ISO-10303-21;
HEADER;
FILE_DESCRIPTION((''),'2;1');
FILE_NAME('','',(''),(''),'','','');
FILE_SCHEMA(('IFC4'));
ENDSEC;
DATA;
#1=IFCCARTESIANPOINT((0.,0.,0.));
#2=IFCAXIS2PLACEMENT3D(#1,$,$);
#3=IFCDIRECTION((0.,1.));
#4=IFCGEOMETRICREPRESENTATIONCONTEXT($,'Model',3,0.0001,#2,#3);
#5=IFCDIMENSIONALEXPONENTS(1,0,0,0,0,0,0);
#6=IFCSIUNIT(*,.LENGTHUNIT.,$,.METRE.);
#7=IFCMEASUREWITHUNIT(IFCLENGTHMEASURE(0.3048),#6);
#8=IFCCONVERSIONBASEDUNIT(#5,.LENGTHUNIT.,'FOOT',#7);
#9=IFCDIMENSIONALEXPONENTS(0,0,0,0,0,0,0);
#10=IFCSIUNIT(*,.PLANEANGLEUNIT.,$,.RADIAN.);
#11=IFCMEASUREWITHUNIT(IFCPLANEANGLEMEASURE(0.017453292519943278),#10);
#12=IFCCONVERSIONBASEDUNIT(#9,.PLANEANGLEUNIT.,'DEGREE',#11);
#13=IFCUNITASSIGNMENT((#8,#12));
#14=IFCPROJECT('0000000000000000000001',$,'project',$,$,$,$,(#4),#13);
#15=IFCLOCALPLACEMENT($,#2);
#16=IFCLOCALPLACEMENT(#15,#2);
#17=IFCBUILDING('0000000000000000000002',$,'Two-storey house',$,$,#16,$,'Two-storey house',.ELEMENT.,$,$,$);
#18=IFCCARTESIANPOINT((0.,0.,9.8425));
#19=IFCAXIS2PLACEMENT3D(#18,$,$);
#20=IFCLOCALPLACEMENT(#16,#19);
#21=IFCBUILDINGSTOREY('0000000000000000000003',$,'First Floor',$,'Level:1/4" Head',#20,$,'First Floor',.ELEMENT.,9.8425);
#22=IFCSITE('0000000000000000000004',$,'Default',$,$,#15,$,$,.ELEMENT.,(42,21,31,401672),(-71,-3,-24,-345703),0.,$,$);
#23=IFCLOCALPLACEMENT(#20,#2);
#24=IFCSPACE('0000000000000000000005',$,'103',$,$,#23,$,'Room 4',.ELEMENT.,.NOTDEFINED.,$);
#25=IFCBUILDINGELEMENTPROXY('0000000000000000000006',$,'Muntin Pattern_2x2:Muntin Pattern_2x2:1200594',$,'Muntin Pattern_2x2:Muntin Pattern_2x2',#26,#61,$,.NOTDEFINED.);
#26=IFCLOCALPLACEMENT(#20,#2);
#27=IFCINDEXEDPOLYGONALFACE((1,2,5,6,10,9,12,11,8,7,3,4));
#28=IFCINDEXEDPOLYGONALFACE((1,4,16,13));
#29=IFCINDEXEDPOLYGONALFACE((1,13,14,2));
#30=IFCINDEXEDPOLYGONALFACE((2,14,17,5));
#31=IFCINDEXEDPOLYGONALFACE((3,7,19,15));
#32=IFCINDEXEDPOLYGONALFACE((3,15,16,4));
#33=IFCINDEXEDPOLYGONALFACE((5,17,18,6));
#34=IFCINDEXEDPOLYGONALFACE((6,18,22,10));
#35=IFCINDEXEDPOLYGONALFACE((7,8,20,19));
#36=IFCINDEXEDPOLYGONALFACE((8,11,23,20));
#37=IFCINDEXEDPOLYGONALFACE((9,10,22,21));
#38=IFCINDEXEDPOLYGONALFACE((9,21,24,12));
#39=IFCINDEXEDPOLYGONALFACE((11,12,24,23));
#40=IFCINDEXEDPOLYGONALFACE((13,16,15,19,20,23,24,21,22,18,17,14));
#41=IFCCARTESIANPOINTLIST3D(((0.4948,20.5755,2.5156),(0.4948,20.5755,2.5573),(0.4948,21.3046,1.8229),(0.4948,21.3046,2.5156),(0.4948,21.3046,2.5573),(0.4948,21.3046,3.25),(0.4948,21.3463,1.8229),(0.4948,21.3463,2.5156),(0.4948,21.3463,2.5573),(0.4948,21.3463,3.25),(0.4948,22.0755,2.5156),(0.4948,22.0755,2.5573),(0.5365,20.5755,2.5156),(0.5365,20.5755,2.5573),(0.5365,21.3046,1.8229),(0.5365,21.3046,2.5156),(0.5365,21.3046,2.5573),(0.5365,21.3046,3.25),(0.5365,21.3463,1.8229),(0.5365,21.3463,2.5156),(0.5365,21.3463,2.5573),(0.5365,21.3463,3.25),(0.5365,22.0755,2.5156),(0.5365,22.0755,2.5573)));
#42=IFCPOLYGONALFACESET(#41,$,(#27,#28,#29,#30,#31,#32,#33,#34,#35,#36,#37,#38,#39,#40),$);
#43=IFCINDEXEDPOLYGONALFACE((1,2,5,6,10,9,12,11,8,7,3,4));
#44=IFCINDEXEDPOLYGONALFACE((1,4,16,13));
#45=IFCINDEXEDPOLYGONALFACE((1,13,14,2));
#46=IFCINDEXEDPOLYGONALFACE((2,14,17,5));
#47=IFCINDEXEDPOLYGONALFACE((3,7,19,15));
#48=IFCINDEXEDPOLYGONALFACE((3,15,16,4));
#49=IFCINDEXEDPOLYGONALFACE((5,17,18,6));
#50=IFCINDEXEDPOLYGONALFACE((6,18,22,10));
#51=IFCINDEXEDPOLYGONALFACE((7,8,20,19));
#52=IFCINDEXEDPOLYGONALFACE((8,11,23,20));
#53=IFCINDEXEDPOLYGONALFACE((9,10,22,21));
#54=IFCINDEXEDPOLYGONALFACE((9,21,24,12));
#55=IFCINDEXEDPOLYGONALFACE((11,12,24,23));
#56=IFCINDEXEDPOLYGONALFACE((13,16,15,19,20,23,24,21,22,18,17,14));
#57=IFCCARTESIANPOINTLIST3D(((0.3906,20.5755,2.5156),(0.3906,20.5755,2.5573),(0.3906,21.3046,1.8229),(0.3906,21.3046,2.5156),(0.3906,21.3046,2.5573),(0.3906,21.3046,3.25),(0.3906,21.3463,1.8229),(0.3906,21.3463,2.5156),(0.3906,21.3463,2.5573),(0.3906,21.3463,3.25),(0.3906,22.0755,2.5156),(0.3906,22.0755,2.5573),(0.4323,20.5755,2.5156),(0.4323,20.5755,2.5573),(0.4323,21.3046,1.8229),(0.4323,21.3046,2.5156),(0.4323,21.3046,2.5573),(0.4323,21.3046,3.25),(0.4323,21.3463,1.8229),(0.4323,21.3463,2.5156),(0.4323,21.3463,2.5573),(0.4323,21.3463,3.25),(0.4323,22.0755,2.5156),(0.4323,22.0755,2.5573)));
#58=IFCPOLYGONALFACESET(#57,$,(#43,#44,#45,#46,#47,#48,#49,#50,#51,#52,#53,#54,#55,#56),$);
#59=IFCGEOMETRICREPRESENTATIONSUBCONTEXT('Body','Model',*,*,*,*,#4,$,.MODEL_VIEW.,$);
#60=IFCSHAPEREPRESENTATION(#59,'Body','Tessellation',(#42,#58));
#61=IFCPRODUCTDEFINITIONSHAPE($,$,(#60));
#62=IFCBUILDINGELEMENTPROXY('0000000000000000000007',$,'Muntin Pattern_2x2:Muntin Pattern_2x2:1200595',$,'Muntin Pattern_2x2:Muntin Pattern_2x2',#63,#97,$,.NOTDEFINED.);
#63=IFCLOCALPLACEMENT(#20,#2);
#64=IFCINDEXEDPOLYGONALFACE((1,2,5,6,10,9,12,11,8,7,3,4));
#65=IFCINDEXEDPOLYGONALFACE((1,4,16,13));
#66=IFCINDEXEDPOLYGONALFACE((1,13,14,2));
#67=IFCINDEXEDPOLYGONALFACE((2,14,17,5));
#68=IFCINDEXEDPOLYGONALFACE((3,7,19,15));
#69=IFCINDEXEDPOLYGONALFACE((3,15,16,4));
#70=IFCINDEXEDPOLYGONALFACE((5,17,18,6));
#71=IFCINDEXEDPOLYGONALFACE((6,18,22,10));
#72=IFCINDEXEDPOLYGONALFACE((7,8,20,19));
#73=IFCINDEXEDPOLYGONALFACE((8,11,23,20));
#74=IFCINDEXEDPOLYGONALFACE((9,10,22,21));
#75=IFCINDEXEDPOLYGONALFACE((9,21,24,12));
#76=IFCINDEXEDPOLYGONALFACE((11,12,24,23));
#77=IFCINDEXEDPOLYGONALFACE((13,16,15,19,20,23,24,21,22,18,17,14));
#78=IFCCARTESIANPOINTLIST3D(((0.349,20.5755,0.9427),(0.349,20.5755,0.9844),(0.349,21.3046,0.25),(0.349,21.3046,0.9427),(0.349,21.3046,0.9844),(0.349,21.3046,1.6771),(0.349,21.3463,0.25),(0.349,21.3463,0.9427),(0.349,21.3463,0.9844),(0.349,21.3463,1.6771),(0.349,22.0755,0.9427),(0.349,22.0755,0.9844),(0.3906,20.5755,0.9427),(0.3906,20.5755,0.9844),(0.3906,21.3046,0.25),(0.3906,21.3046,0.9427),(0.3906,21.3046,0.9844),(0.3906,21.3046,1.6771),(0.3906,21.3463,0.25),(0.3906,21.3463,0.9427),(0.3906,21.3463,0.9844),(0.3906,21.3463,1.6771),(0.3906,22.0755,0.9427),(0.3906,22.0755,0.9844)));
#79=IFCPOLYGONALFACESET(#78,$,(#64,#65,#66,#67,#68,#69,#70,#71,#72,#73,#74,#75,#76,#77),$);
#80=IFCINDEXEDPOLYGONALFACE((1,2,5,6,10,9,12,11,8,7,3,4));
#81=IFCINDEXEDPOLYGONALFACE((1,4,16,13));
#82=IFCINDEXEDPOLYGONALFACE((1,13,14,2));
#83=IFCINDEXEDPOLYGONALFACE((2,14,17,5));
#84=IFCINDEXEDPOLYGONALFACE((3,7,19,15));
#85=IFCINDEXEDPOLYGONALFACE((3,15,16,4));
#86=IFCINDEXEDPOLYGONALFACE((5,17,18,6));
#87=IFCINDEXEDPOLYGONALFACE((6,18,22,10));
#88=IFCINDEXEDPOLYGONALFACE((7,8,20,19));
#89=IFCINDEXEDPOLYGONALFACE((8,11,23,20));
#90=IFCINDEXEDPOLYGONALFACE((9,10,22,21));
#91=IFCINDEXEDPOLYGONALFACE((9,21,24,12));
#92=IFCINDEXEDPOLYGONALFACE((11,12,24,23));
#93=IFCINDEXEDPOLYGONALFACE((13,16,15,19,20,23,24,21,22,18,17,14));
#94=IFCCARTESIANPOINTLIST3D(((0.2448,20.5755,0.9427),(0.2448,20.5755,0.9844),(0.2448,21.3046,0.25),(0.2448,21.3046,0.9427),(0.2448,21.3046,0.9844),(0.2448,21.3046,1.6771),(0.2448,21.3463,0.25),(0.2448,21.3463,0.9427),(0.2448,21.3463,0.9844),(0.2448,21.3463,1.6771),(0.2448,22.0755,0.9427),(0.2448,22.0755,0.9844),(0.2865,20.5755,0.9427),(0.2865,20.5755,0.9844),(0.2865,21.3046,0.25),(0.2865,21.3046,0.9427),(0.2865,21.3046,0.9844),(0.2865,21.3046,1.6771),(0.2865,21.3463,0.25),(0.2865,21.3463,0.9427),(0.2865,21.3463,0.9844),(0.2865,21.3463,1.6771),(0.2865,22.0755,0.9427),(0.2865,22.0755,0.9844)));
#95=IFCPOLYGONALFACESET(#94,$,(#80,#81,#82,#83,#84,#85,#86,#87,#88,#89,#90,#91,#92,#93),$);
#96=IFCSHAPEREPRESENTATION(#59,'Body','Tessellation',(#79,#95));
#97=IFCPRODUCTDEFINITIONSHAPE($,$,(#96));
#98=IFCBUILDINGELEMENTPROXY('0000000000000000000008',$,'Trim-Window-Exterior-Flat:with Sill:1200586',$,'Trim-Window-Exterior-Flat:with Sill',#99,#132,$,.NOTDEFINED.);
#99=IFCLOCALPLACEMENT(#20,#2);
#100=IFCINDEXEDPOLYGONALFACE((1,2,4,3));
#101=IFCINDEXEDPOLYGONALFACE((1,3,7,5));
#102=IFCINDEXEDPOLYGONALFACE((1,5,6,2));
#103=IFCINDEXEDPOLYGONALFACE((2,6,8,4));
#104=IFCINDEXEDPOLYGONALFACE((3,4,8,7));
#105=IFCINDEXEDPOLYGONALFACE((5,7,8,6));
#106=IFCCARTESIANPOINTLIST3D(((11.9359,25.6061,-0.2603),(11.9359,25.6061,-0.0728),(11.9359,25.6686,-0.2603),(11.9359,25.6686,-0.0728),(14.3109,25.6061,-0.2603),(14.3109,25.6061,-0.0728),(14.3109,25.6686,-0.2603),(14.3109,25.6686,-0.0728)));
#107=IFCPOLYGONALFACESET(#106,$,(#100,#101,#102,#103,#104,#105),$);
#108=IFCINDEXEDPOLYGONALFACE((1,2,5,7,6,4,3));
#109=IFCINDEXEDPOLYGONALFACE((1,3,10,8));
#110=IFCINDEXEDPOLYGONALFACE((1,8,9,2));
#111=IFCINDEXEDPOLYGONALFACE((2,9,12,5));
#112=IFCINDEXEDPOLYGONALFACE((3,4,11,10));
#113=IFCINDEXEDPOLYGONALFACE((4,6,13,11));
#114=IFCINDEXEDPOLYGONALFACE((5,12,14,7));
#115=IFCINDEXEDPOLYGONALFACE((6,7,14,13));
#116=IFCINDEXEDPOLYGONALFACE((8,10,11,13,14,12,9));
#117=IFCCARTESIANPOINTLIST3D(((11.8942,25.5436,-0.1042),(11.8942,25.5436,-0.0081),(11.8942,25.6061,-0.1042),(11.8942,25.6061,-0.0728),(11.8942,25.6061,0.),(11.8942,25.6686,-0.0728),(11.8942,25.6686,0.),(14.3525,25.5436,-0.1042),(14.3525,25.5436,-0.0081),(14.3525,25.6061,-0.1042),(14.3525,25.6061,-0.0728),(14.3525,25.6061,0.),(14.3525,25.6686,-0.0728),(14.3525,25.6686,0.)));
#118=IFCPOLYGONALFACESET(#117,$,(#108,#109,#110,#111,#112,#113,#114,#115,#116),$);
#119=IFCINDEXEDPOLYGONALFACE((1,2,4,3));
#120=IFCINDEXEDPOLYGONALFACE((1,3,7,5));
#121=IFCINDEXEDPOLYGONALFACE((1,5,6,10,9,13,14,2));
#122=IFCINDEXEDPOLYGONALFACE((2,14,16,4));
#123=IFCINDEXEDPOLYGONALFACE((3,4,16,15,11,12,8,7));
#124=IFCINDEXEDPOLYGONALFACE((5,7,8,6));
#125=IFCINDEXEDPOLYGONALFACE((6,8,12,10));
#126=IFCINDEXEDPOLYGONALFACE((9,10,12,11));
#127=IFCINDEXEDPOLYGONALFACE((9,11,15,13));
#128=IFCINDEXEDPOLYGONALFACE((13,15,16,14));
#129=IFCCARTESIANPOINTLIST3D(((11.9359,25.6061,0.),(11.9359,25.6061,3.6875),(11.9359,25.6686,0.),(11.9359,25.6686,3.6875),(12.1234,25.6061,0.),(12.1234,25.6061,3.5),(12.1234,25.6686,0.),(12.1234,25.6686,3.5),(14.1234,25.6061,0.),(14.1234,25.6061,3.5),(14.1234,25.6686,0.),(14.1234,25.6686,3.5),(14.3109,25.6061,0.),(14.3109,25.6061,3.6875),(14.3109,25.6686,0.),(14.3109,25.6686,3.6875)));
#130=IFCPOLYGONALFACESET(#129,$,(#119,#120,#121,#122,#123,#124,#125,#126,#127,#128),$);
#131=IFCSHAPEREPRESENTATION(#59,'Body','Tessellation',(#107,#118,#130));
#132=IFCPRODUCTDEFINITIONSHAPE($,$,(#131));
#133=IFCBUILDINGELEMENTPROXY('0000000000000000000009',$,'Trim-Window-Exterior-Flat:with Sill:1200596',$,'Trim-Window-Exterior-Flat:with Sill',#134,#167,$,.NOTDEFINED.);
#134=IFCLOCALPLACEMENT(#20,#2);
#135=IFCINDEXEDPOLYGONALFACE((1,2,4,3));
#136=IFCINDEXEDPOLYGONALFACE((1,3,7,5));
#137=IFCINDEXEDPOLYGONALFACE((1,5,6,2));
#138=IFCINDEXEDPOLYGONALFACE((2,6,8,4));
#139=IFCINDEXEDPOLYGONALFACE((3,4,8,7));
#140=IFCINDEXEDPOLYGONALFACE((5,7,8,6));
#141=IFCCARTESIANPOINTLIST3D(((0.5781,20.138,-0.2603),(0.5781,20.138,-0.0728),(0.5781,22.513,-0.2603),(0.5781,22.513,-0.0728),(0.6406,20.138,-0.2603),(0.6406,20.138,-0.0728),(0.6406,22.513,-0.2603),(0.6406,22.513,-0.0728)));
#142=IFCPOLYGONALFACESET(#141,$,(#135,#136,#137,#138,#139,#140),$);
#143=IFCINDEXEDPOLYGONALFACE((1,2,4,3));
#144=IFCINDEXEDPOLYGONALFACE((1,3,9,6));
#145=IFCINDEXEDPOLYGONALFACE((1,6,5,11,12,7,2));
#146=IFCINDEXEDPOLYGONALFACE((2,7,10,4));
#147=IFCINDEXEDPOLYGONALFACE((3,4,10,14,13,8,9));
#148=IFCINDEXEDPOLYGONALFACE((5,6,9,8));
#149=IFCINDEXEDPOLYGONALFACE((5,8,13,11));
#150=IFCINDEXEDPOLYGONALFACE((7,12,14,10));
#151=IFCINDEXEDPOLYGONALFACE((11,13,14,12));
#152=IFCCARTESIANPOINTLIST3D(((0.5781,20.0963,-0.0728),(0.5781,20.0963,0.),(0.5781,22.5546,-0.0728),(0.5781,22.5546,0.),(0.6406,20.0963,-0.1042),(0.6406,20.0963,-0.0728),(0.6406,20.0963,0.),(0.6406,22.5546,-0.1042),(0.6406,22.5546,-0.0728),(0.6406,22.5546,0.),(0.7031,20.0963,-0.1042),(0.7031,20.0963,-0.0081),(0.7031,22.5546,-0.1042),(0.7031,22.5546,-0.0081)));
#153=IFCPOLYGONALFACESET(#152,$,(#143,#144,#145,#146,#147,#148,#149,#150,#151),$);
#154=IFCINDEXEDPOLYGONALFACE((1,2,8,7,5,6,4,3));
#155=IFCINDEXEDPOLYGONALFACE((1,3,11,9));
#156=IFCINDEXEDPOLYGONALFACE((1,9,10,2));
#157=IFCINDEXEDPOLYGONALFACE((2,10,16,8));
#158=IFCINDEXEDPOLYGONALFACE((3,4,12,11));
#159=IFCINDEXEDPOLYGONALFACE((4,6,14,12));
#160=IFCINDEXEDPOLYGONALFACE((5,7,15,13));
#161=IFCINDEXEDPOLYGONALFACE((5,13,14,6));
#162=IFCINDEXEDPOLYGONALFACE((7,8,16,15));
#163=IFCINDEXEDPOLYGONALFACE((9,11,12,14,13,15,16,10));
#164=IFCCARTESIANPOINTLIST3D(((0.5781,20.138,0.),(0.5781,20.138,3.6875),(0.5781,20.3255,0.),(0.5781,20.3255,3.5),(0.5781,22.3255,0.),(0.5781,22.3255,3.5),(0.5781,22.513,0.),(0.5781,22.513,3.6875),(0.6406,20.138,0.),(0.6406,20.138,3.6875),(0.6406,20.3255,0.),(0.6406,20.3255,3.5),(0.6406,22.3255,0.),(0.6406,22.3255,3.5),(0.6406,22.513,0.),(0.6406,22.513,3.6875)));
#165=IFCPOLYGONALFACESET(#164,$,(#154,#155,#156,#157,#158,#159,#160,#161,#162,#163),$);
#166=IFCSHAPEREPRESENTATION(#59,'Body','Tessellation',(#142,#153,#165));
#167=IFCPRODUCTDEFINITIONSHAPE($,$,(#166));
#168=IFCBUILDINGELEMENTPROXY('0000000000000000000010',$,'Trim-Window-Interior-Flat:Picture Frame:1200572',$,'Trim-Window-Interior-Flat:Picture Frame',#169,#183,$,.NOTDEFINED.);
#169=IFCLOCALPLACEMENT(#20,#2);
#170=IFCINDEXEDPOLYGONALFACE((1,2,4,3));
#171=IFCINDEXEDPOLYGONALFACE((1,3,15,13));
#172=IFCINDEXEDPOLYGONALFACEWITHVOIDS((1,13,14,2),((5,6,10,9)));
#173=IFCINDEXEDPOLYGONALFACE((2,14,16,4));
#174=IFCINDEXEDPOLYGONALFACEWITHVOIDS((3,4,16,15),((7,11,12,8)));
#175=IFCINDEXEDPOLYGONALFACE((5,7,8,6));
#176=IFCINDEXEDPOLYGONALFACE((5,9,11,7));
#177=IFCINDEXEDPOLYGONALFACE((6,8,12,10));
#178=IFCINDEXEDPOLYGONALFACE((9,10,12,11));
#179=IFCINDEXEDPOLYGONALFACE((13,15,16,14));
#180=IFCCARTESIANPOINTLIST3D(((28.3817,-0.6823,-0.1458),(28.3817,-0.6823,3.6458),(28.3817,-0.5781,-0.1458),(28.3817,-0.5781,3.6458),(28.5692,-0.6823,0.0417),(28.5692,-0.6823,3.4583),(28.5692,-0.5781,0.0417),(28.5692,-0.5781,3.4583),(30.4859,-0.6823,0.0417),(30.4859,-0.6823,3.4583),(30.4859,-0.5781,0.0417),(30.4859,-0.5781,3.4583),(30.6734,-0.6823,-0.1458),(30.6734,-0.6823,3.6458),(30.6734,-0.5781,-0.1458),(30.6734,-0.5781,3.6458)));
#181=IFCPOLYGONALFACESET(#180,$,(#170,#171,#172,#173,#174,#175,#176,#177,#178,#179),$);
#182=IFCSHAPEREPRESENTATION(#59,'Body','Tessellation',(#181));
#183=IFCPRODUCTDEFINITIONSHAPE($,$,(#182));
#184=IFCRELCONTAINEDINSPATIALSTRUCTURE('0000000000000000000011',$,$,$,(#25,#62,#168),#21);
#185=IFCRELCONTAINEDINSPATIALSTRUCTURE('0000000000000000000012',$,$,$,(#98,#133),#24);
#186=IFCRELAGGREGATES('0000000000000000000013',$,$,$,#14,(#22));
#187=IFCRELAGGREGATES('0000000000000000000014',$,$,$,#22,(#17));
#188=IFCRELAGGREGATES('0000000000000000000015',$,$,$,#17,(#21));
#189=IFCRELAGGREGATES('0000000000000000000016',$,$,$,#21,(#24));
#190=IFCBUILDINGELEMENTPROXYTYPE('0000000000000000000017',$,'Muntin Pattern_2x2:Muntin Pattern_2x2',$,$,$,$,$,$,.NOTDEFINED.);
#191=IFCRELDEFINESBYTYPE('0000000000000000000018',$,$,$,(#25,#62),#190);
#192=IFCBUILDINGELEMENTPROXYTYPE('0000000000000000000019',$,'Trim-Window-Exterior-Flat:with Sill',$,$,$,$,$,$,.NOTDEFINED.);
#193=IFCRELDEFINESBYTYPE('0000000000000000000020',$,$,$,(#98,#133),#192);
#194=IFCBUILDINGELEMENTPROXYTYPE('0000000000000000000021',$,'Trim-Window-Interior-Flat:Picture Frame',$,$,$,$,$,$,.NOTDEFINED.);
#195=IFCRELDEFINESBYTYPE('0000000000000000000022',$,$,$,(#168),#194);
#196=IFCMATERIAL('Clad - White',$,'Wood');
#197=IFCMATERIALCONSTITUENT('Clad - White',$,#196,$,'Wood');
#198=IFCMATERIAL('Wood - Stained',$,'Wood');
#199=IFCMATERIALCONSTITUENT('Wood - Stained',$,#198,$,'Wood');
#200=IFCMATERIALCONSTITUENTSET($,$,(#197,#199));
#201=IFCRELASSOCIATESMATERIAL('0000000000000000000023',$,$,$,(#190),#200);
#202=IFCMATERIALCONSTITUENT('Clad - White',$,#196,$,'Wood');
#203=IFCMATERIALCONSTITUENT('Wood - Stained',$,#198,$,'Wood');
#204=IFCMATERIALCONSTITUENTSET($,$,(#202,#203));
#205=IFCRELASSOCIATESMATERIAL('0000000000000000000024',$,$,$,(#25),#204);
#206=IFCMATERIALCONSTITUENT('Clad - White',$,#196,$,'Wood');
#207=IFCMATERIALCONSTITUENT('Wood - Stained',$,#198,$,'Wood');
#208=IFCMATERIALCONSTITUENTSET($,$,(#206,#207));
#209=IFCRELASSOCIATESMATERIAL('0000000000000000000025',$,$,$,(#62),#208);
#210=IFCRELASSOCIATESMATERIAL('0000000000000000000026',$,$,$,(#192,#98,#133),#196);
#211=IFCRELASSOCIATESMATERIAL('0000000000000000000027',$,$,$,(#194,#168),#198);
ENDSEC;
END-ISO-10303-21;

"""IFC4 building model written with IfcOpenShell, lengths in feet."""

from ifc_helpers import new_model, entity, si_unit, converted_unit, direction, frame, origin, place, context, subcontext, project, spatial, indexed_curve, outline, extrude, source, transform, mapped, material, constituent, constituent_set, type_object, type_shapes, element, save


model = new_model("IFC4")

# Units and contexts
model_context = context("Model", 3, precision=0.0001, world=origin(), true_north=direction((0.0, 1.0)))
body_context = subcontext(model_context, "Body", "Model", "MODEL_VIEW")
ifc_project = project(units=[converted_unit("LENGTHUNIT", "FOOT", entity("IfcLengthMeasure", 0.3048), si_unit("LENGTHUNIT", "METRE"), dimensions=[1, 0, 0, 0, 0, 0, 0]), converted_unit("PLANEANGLEUNIT", "DEGREE", entity("IfcPlaneAngleMeasure", 0.017453292519943278), si_unit("PLANEANGLEUNIT", "RADIAN"), dimensions=[0, 0, 0, 0, 0, 0, 0])], contexts=[model_context])

# Site, building, storey
site_placement = place(None, origin())
site = spatial("IfcSite", under=ifc_project, at=site_placement, Name="Default", CompositionType="ELEMENT", RefLatitude=(42, 21, 31, 401672), RefLongitude=(-71, -3, -24, -345703), RefElevation=0.0)
building_placement = place(site_placement, origin())
building = spatial("IfcBuilding", under=site, at=building_placement, Name="Two-storey house", LongName="Two-storey house", CompositionType="ELEMENT")
storey_placement = place(building_placement, frame((0.0, 0.0, 9.8425)))
storey = spatial("IfcBuildingStorey", under=building, at=storey_placement, Name="First Floor", ObjectType="Level:1/4\" Head", LongName="First Floor", CompositionType="ELEMENT", Elevation=9.8425)

# Shared definitions
ifc_material_1 = material(Name="Wood - Stained", Category="Wood")

# Building element proxies
ifc_material_2 = material(Name="Clad - White", Category="Wood")
ifc_constituent_1 = constituent(ifc_material_2, Name="Clad - White", Category="Wood")
ifc_constituent_2 = constituent(ifc_material_1, Name="Wood - Stained", Category="Wood")
ifc_constituent_set_1 = constituent_set(constituents=[ifc_constituent_1, ifc_constituent_2])
building_element_proxy_type_1 = type_object("IfcBuildingElementProxyType", Name="Muntin Pattern_2x2:Muntin Pattern_2x2", PredefinedType="NOTDEFINED", material=ifc_constituent_set_1)
shared_shape_1 = source(origin(), body_context, "Body", "SweptSolid", [
    extrude(outline(indexed_curve([(0.0208, -0.0208), (0.7135, -0.0208), (0.7135, 0.0208), (0.0208, 0.0208), (0.0208, 0.75), (-0.0208, 0.75), (-0.0208, 0.0208), (-0.7135, 0.0208), (-0.7135, -0.0208), (-0.0208, -0.0208), (-0.0208, -0.75), (0.0208, -0.75), (0.0208, -0.0208)], self_intersect=False)), frame((0.0, 0.0312, 0.7135), z_axis=(0.0, 1.0, 0.0), x_axis=(0.0, 0.0, 1.0)), (0.0, 0.0, 1.0), 0.0417),
    extrude(outline(indexed_curve([(0.0208, -0.0208), (0.7135, -0.0208), (0.7135, 0.0208), (0.0208, 0.0208), (0.0208, 0.75), (-0.0208, 0.75), (-0.0208, 0.0208), (-0.7135, 0.0208), (-0.7135, -0.0208), (-0.0208, -0.0208), (-0.0208, -0.75), (0.0208, -0.75), (0.0208, -0.0208)], self_intersect=False)), frame((0.0, -0.0729, 0.7135), z_axis=(0.0, 1.0, 0.0), x_axis=(0.0, 0.0, 1.0)), (0.0, 0.0, 1.0), 0.0417),
])
type_shapes(building_element_proxy_type_1, [shared_shape_1])
ifc_constituent_3 = constituent(ifc_material_2, Name="Clad - White", Category="Wood")
ifc_constituent_4 = constituent(ifc_material_1, Name="Wood - Stained", Category="Wood")
ifc_constituent_set_2 = constituent_set(constituents=[ifc_constituent_3, ifc_constituent_4])
proxy_1_placement = place(storey_placement, frame((0.4635, 21.3255, 1.8229), z_axis=(0.0, 0.0, 1.0), x_axis=(0.0, -1.0, 0.0)))
element("IfcBuildingElementProxy", 1, at=proxy_1_placement, inside=storey, type_object=building_element_proxy_type_1, material=ifc_constituent_set_2, Name="Muntin Pattern_2x2:Muntin Pattern_2x2:1200594", ObjectType="Muntin Pattern_2x2:Muntin Pattern_2x2", PredefinedType="NOTDEFINED", context=body_context, shape_type="MappedRepresentation", body=[
    mapped(shared_shape_1, transform((0.0, 0.0, 0.0), scale=1.0)),
])
ifc_constituent_5 = constituent(ifc_material_2, Name="Clad - White", Category="Wood")
ifc_constituent_6 = constituent(ifc_material_1, Name="Wood - Stained", Category="Wood")
ifc_constituent_set_3 = constituent_set(constituents=[ifc_constituent_5, ifc_constituent_6])
proxy_2_placement = place(storey_placement, frame((0.3177, 21.3255, 0.25), z_axis=(0.0, 0.0, 1.0), x_axis=(0.0, -1.0, 0.0)))
element("IfcBuildingElementProxy", 2, at=proxy_2_placement, inside=storey, type_object=building_element_proxy_type_1, material=ifc_constituent_set_3, Name="Muntin Pattern_2x2:Muntin Pattern_2x2:1200595", ObjectType="Muntin Pattern_2x2:Muntin Pattern_2x2", PredefinedType="NOTDEFINED", context=body_context, shape_type="MappedRepresentation", body=[
    mapped(shared_shape_1, transform((0.0, 0.0, 0.0), scale=1.0)),
])

# Shared definitions
space_placement = place(storey_placement, origin())
space = spatial("IfcSpace", under=storey, at=space_placement, Name="103", LongName="Room 4", CompositionType="ELEMENT", PredefinedType="NOTDEFINED")

# Building element proxies
building_element_proxy_type_2 = type_object("IfcBuildingElementProxyType", Name="Trim-Window-Exterior-Flat:with Sill", PredefinedType="NOTDEFINED", material=ifc_material_2)
shared_shape_2 = source(origin(), body_context, "Body", "SweptSolid", [
    extrude(outline(indexed_curve([(-1.1875, -0.0938), (1.1875, -0.0938), (1.1875, 0.0938), (-1.1875, 0.0938), (-1.1875, -0.0938)], self_intersect=False)), frame((0.0, -3.6665, 0.0), z_axis=(0.0, 0.0, 1.0), x_axis=(-1.0, 0.0, 0.0)), (0.0, 0.0, 1.0), 0.0625),
    extrude(outline(indexed_curve([(-0.0625, -0.0525), (0.0, -0.0525), (0.0, -0.0211), (0.0625, -0.0211), (0.0625, 0.0517), (0.0, 0.0517), (-0.0625, 0.0436), (-0.0625, -0.0525)], self_intersect=False)), frame((-1.2292, -3.5517, 0.0625), z_axis=(1.0, 0.0, 0.0), x_axis=(0.0, 0.0, -1.0)), (0.0, 0.0, 1.0), 2.4583),
    extrude(outline(indexed_curve([(-1.8906, -1.1875), (1.7969, -1.1875), (1.7969, -1.0), (-1.7031, -1.0), (-1.7031, 1.0), (1.7969, 1.0), (1.7969, 1.1875), (-1.8906, 1.1875), (-1.8906, -1.1875)], self_intersect=False)), frame((0.0, -1.7031, 0.0), z_axis=(0.0, 0.0, 1.0), x_axis=(0.0, -1.0, 0.0)), (0.0, 0.0, 1.0), 0.0625),
])
type_shapes(building_element_proxy_type_2, [shared_shape_2])
for number, where, z_axis, x_axis, name in (
    (3, (13.1234, 25.6686, 3.5), (0.0, -1.0, 0.0), (1.0, 0.0, 0.0), "Trim-Window-Exterior-Flat:with Sill:1200586"),
    (4, (0.5781, 21.3255, 3.5), (1.0, 0.0, 0.0), (0.0, 1.0, 0.0), "Trim-Window-Exterior-Flat:with Sill:1200596"),
):
    element("IfcBuildingElementProxy", number, at=place(space_placement, frame(where, z_axis=z_axis, x_axis=x_axis)), inside=space, type_object=building_element_proxy_type_2, material=ifc_material_2, Name=name, ObjectType="Trim-Window-Exterior-Flat:with Sill", PredefinedType="NOTDEFINED", context=body_context, shape_type="MappedRepresentation", body=[
        mapped(shared_shape_2, transform((0.0, 0.0, 0.0), scale=1.0)),
    ])
building_element_proxy_type_3 = type_object("IfcBuildingElementProxyType", Name="Trim-Window-Interior-Flat:Picture Frame", PredefinedType="NOTDEFINED", material=ifc_material_1)
shared_shape_3 = source(origin(), body_context, "Body", "SweptSolid", [
    extrude(outline(indexed_curve([(-1.1458, -1.8958), (1.1458, -1.8958), (1.1458, 1.8958), (-1.1458, 1.8958), (-1.1458, -1.8958)], self_intersect=False), holes=[indexed_curve([(-0.9583, -1.7083), (-0.9583, 1.7083), (0.9583, 1.7083), (0.9583, -1.7083), (-0.9583, -1.7083)], self_intersect=False)]), frame((0.0, -1.75, 0.0), z_axis=(0.0, 0.0, 1.0), x_axis=(-1.0, 0.0, 0.0)), (0.0, 0.0, 1.0), 0.1042),
])
type_shapes(building_element_proxy_type_3, [shared_shape_3])
for number, where, z_axis, x_axis, name in (
    (5, (29.5276, -0.5781, 3.5), (0.0, -1.0, 0.0), (1.0, 0.0, 0.0), "Trim-Window-Interior-Flat:Picture Frame:1200572"),
):
    element("IfcBuildingElementProxy", number, at=place(storey_placement, frame(where, z_axis=z_axis, x_axis=x_axis)), inside=storey, type_object=building_element_proxy_type_3, material=ifc_material_1, Name=name, ObjectType="Trim-Window-Interior-Flat:Picture Frame", PredefinedType="NOTDEFINED", context=body_context, shape_type="MappedRepresentation", body=[
        mapped(shared_shape_3, transform((0.0, 0.0, 0.0), scale=1.0)),
    ])

save(model, "model.ifc")
